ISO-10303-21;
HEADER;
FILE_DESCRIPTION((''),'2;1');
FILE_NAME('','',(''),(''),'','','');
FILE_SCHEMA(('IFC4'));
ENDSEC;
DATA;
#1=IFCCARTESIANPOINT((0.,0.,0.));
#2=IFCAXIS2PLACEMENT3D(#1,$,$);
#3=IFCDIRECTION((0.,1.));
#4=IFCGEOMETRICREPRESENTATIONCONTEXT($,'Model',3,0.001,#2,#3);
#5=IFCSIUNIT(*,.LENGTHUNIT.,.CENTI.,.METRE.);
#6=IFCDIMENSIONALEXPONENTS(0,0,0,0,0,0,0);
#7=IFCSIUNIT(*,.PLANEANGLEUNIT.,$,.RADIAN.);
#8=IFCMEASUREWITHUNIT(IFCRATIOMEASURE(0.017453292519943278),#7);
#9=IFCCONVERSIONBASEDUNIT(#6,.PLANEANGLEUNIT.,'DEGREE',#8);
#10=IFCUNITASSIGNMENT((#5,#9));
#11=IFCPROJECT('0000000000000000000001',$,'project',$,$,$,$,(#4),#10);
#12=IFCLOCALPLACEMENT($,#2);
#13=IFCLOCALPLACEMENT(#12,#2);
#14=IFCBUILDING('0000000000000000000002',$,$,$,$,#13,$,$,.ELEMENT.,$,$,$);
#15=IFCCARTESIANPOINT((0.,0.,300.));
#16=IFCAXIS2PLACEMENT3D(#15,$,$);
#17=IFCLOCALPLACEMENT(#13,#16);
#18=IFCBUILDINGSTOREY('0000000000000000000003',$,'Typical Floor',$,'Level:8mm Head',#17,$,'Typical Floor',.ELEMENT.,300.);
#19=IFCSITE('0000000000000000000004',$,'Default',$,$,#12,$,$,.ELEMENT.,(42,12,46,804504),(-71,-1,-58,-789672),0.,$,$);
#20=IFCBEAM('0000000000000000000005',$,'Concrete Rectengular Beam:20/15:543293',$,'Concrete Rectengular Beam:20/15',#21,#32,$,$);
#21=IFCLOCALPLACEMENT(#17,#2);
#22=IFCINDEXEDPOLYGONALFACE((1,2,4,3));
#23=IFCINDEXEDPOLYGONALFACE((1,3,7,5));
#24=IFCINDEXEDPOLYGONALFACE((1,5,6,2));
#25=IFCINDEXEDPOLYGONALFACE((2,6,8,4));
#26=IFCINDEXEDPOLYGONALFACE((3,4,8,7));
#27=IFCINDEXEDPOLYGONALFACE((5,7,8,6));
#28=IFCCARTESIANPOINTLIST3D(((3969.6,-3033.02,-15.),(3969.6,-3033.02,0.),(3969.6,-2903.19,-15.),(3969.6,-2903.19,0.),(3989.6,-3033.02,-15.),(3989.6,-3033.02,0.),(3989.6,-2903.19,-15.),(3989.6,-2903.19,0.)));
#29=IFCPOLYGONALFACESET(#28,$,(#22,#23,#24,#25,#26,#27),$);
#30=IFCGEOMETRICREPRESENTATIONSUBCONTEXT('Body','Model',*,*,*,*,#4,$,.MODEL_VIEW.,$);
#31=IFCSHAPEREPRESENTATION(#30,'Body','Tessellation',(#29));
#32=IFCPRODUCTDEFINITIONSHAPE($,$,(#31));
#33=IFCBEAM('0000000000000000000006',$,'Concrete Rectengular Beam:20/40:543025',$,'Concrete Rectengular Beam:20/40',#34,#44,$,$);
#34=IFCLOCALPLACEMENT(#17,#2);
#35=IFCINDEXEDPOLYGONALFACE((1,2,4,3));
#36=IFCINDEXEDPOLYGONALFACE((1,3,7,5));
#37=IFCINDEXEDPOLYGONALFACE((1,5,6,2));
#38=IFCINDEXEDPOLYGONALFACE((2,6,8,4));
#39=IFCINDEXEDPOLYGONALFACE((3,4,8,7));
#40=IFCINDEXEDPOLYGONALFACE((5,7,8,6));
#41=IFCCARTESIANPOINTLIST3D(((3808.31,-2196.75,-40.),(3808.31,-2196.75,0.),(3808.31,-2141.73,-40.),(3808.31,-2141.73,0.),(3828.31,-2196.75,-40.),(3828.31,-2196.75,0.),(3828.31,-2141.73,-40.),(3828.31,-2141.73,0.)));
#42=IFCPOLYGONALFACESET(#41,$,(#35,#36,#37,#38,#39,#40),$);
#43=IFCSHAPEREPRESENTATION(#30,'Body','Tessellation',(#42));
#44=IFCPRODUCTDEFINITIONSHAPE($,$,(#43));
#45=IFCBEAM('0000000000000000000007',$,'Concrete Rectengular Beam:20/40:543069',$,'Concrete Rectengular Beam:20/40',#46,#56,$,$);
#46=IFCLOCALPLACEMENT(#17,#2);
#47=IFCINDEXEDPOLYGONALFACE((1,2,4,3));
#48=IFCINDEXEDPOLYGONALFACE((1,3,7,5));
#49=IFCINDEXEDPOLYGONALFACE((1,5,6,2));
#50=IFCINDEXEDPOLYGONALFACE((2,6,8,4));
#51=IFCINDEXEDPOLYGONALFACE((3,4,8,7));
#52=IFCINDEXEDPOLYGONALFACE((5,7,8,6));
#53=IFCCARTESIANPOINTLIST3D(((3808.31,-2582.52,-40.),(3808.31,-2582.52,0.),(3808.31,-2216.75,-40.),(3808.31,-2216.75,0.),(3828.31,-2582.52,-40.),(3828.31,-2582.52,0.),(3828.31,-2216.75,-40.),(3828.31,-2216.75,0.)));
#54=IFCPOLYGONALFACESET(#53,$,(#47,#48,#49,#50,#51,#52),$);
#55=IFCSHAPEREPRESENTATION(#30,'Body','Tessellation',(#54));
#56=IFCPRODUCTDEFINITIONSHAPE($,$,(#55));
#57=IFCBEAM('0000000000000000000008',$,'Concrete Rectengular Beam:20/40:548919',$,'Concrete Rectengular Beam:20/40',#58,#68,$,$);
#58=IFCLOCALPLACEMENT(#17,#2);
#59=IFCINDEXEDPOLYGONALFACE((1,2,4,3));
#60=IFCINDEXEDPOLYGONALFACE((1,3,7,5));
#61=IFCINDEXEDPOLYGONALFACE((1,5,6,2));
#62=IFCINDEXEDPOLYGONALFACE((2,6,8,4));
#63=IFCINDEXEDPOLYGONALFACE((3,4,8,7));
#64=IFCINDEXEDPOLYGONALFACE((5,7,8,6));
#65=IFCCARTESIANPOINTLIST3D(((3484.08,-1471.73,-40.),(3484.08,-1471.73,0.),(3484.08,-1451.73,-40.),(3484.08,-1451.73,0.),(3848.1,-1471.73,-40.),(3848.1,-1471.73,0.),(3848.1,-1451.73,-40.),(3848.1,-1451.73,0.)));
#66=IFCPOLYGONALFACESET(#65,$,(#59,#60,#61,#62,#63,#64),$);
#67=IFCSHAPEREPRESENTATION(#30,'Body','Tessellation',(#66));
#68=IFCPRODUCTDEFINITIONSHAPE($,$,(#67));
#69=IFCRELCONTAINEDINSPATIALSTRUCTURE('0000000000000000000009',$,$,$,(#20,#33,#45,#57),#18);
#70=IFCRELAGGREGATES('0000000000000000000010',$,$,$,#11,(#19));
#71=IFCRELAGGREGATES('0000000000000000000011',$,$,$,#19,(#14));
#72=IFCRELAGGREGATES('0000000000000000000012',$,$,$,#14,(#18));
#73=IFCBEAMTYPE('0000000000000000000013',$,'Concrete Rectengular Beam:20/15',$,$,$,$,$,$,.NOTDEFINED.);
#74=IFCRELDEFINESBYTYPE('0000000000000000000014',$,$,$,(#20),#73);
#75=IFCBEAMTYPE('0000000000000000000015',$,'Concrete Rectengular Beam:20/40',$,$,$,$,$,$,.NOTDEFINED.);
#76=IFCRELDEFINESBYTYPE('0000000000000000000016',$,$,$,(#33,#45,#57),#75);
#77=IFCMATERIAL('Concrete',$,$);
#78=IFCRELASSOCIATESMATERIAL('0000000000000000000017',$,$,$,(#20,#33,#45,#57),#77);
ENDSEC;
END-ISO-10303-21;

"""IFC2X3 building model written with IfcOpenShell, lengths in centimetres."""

from ifc_helpers import new_model, entity, si_unit, converted_unit, direction, frame, frame_2d, origin, place, context, subcontext, project, spatial, rectangle, extrude, material, type_object, element, save


model = new_model("IFC2X3")

# Units and contexts
model_context = context("Model", 3, precision=0.001, world=origin(), true_north=direction((0.0, 1.0)))
body_context = subcontext(model_context, "Body", "Model", "MODEL_VIEW")
ifc_project = project(units=[si_unit("LENGTHUNIT", "METRE", prefix="CENTI"), converted_unit("PLANEANGLEUNIT", "DEGREE", entity("IfcRatioMeasure", 0.017453292519943278), si_unit("PLANEANGLEUNIT", "RADIAN"), dimensions=[0, 0, 0, 0, 0, 0, 0])], contexts=[model_context])

# Site, building, storey
site_placement = place(None, origin())
site = spatial("IfcSite", under=ifc_project, at=site_placement, Name="Default", CompositionType="ELEMENT", RefLatitude=(42, 12, 46, 804504), RefLongitude=(-71, -1, -58, -789672), RefElevation=0.0)
building_placement = place(site_placement, origin())
building = spatial("IfcBuilding", under=site, at=building_placement, CompositionType="ELEMENT")
storey_placement = place(building_placement, frame((0.0, 0.0, 300.0)))
storey = spatial("IfcBuildingStorey", under=building, at=storey_placement, Name="Typical Floor", ObjectType="Level:8mm Head", LongName="Typical Floor", CompositionType="ELEMENT", Elevation=300.0)

# Beams
ifc_material = material(Name="Concrete")
beam_type_1 = type_object("IfcBeamType", Name="Concrete Rectengular Beam:20/15", PredefinedType="NOTDEFINED")
beam_1_placement = place(storey_placement, frame((3979.6, -2893.19, 0.0), z_axis=(0.0, 0.0, 1.0), x_axis=(0.0, -1.0, 0.0)))
element("IfcBeam", 1, at=beam_1_placement, inside=storey, type_object=beam_type_1, material=ifc_material, Name="Concrete Rectengular Beam:20/15:543293", ObjectType="Concrete Rectengular Beam:20/15", context=body_context, shape_type="SweptSolid", body=[
    extrude(rectangle(XDim=15.0, YDim=20.0, at=frame_2d((0.0, 0.0), x_axis=(1.0, 0.0))), frame((10.0, 0.0, -7.5), z_axis=(1.0, 0.0, 0.0), x_axis=(0.0, 0.0, -1.0)), (0.0, 0.0, 1.0), 129.83),
])
beam_type_2 = type_object("IfcBeamType", Name="Concrete Rectengular Beam:20/40", PredefinedType="NOTDEFINED")
beam_2_placement = place(storey_placement, frame((3818.31, -2206.75, 0.0), z_axis=(0.0, 0.0, 1.0), x_axis=(0.0, 1.0, 0.0)))
element("IfcBeam", 2, at=beam_2_placement, inside=storey, type_object=beam_type_2, material=ifc_material, Name="Concrete Rectengular Beam:20/40:543025", ObjectType="Concrete Rectengular Beam:20/40", context=body_context, shape_type="SweptSolid", body=[
    extrude(rectangle(XDim=40.0, YDim=20.0, at=frame_2d((0.0, 0.0), x_axis=(1.0, 0.0))), frame((10.0, 0.0, -20.0), z_axis=(1.0, 0.0, 0.0), x_axis=(0.0, 0.0, -1.0)), (0.0, 0.0, 1.0), 55.02),
])
beam_3_placement = place(storey_placement, frame((3818.31, -2206.75, 0.0), z_axis=(0.0, 0.0, 1.0), x_axis=(0.0, -1.0, 0.0)))
element("IfcBeam", 3, at=beam_3_placement, inside=storey, type_object=beam_type_2, material=ifc_material, Name="Concrete Rectengular Beam:20/40:543069", ObjectType="Concrete Rectengular Beam:20/40", context=body_context, shape_type="SweptSolid", body=[
    extrude(rectangle(XDim=40.0, YDim=20.0, at=frame_2d((0.0, 0.0), x_axis=(1.0, 0.0))), frame((10.0, 0.0, -20.0), z_axis=(1.0, 0.0, 0.0), x_axis=(0.0, 0.0, -1.0)), (0.0, 0.0, 1.0), 365.78),
])
beam_4_placement = place(storey_placement, frame((3868.1, -1461.73, 0.0), z_axis=(0.0, 0.0, 1.0), x_axis=(-1.0, 0.0, 0.0)))
element("IfcBeam", 4, at=beam_4_placement, inside=storey, type_object=beam_type_2, material=ifc_material, Name="Concrete Rectengular Beam:20/40:548919", ObjectType="Concrete Rectengular Beam:20/40", context=body_context, shape_type="SweptSolid", body=[
    extrude(rectangle(XDim=40.0, YDim=20.0, at=frame_2d((0.0, 0.0), x_axis=(1.0, 0.0))), frame((20.0, 0.0, -20.0), z_axis=(1.0, 0.0, 0.0), x_axis=(0.0, 0.0, -1.0)), (0.0, 0.0, 1.0), 364.01),
])

save(model, "model.ifc")
